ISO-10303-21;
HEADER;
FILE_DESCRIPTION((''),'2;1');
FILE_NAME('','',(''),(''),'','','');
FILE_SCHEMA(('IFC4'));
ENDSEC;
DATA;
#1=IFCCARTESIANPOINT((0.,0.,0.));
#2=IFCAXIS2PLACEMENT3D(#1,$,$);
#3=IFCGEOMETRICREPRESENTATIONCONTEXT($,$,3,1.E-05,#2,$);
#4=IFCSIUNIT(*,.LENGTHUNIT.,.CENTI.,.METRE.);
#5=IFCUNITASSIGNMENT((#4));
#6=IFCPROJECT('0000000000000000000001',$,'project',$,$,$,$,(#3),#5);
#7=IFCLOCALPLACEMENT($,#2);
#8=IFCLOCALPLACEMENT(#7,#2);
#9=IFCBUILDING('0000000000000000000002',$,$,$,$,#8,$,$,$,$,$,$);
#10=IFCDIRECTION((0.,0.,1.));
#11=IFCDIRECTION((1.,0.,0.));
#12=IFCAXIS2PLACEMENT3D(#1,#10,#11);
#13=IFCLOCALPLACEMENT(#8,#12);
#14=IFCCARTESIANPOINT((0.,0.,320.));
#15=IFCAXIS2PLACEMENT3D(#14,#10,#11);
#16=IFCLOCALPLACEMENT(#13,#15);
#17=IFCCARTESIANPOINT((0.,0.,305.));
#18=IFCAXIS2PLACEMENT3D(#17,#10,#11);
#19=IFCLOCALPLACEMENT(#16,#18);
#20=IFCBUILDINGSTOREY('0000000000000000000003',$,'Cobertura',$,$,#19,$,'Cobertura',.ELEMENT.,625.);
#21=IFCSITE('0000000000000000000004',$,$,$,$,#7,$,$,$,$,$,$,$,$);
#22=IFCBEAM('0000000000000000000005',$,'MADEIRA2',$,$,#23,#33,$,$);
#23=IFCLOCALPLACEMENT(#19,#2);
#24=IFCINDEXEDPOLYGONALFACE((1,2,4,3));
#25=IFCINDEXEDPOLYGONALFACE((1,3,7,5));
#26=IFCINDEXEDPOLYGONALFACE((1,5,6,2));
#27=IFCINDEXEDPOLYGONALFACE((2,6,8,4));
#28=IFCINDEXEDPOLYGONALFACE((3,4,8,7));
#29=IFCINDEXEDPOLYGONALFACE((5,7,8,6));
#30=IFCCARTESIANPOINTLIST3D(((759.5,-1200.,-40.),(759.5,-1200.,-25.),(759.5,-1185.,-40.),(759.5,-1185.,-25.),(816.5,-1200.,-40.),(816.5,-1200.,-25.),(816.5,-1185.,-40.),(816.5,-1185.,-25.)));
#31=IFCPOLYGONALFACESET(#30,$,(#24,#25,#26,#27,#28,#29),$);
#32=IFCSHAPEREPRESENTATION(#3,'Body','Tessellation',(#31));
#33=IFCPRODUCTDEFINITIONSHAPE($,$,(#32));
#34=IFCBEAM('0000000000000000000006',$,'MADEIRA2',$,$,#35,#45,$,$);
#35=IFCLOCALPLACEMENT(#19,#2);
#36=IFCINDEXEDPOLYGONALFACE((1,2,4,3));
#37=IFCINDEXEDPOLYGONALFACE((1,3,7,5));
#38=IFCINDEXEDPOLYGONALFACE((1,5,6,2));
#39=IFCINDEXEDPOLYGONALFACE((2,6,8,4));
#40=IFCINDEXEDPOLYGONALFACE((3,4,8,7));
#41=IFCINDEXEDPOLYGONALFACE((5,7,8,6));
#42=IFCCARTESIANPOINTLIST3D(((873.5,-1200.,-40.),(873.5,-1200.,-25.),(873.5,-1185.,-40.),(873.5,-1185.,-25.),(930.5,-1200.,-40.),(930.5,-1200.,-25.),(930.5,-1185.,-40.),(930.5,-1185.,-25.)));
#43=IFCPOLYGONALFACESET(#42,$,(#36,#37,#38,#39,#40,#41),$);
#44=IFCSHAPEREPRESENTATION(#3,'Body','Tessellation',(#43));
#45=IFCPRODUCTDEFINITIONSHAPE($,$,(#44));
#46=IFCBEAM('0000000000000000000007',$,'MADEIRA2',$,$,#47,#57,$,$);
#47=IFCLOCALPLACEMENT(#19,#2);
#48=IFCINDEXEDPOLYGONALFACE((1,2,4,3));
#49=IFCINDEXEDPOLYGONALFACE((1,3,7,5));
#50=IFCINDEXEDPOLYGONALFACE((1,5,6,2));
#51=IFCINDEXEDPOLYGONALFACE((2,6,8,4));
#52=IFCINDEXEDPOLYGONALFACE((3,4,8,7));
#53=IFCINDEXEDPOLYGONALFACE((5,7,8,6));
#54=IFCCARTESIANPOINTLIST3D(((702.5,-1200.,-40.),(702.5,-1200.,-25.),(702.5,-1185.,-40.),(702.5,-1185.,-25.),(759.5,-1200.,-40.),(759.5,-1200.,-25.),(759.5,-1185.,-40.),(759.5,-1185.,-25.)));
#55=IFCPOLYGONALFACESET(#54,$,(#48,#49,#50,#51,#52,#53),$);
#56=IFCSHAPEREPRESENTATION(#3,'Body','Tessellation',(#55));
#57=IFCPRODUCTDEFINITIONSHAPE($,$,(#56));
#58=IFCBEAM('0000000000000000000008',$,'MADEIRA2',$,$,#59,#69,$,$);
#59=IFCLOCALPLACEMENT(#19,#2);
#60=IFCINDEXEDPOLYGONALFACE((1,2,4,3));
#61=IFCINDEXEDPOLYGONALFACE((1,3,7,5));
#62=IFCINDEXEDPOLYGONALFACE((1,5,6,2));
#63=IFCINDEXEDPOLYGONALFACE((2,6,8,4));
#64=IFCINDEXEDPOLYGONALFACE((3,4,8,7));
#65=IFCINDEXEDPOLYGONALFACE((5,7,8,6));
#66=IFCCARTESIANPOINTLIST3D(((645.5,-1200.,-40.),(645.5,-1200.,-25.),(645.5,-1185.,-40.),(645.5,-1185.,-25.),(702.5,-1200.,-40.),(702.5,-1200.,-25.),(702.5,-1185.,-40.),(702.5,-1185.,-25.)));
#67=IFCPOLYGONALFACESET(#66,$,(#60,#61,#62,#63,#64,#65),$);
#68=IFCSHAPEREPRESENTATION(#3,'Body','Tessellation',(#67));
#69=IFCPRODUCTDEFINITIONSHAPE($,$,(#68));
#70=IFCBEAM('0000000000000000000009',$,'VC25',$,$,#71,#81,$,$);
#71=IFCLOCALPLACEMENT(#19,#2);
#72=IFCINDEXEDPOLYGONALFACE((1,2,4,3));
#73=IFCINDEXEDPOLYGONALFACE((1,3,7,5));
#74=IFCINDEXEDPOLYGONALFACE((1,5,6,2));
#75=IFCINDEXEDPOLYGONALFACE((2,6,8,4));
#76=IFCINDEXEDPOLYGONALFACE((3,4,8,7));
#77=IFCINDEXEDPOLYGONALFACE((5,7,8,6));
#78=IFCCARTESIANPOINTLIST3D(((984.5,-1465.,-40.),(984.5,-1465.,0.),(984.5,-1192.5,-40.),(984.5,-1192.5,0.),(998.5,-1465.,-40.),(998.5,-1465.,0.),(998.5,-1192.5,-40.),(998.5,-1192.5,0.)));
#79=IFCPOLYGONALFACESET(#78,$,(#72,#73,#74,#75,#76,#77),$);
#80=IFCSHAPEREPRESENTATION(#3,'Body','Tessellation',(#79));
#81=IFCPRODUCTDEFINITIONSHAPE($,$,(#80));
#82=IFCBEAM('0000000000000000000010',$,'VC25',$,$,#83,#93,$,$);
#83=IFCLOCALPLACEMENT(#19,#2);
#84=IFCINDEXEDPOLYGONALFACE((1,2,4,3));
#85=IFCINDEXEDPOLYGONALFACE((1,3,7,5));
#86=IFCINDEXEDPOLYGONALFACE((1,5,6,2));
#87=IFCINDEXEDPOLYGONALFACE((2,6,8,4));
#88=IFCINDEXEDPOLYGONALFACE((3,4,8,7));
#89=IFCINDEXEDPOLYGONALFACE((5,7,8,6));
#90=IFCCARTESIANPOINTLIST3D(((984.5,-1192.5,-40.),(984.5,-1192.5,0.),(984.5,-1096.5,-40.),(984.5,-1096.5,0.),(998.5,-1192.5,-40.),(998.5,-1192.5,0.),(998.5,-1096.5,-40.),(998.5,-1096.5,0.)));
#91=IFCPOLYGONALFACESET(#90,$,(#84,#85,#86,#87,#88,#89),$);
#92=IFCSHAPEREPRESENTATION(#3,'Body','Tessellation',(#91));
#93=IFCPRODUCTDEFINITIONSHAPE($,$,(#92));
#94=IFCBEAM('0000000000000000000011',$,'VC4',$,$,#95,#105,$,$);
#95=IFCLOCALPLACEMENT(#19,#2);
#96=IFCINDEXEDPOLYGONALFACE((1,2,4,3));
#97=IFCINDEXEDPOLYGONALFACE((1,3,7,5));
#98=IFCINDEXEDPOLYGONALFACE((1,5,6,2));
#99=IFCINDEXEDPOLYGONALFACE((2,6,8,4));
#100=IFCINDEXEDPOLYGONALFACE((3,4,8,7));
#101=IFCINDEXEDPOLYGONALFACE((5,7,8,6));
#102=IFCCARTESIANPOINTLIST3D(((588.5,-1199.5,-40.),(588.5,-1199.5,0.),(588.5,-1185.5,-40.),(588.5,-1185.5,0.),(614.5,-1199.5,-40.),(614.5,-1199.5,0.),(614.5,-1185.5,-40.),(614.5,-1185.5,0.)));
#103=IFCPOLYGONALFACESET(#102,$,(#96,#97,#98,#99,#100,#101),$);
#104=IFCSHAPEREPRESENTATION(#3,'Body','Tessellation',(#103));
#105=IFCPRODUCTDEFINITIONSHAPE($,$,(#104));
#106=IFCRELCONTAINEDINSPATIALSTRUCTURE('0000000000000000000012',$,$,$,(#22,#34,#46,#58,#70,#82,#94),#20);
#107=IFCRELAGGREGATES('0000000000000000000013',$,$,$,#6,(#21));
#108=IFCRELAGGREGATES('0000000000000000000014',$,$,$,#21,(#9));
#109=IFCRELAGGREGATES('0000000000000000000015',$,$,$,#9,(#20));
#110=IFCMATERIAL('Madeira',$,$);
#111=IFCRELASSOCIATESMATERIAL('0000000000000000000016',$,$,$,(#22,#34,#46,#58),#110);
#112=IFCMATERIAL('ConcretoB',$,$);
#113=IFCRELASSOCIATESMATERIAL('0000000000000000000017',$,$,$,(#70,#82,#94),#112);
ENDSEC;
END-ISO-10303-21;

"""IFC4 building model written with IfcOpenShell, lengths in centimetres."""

from ifc_helpers import new_model, si_unit, frame, origin, origin_with_axes, place, context, project, spatial, polyline, outline, extrude, material, element, save


model = new_model("IFC4")

# Units and contexts
context_of_model = context(None, 3, precision=1e-05, world=origin())
ifc_project = project(units=[si_unit("LENGTHUNIT", "METRE", prefix="CENTI")], contexts=[context_of_model])

# Site, building, storey
site_placement = place(None, origin())
site = spatial("IfcSite", under=ifc_project, at=site_placement)
building_placement = place(site_placement, origin())
building = spatial("IfcBuilding", under=site, at=building_placement)
placement_1 = place(building_placement, origin_with_axes())
placement_2 = place(placement_1, frame((0.0, 0.0, 320.0), z_axis=(0.0, 0.0, 1.0), x_axis=(1.0, 0.0, 0.0)))
storey_placement = place(placement_2, frame((0.0, 0.0, 305.0), z_axis=(0.0, 0.0, 1.0), x_axis=(1.0, 0.0, 0.0)))
storey = spatial("IfcBuildingStorey", under=building, at=storey_placement, Name="Cobertura", LongName="Cobertura", CompositionType="ELEMENT", Elevation=625.0)

# Shared definitions
ifc_material_1 = material(Name="ConcretoB")

# Beams
ifc_material_2 = material(Name="Madeira")
for number, where, z_axis, x_axis, name in (
    (1, (788.0, -1192.5, -25.0), (0.0, 0.0, 1.0), (1.0, 0.0, 0.0), "MADEIRA2"),
    (2, (902.0, -1192.5, -25.0), (0.0, 0.0, 1.0), (1.0, 0.0, 0.0), "MADEIRA2"),
    (3, (731.0, -1192.5, -25.0), (0.0, 0.0, 1.0), (1.0, 0.0, 0.0), "MADEIRA2"),
    (4, (674.0, -1192.5, -25.0), (0.0, 0.0, 1.0), (1.0, 0.0, 0.0), "MADEIRA2"),
):
    element("IfcBeam", number, at=place(storey_placement, frame(where, z_axis=z_axis, x_axis=x_axis)), inside=storey, material=ifc_material_2, Name=name, context=context_of_model, shape_type="SolidModel", body=[
        extrude(outline(polyline([(-7.5, -7.5), (-7.5, 7.5), (7.5, 7.5), (7.5, -7.5), (-7.5, -7.5)])), frame((-28.5, 0.0, -7.5), z_axis=(1.0, 0.0, 0.0), x_axis=(0.0, -1.0, 0.0)), (0.0, 0.0, 1.0), 57.0),
    ])
beam_1_placement = place(storey_placement, frame((991.5, -1328.75, 0.0), z_axis=(0.0, 0.0, 1.0), x_axis=(1.0, 0.0, 0.0)))
element("IfcBeam", 5, at=beam_1_placement, inside=storey, material=ifc_material_1, Name="VC25", context=context_of_model, shape_type="SolidModel", body=[
    extrude(outline(polyline([(-7.0, -20.0), (7.0, -20.0), (7.0, 20.0), (-7.0, 20.0), (-7.0, -20.0)])), frame((0.0, -136.25, -20.0), z_axis=(0.0, 1.0, 0.0), x_axis=(1.0, 0.0, 0.0)), (0.0, 0.0, 1.0), 272.5),
])
beam_2_placement = place(storey_placement, frame((991.5, -1144.5, 0.0), z_axis=(0.0, 0.0, 1.0), x_axis=(1.0, 0.0, 0.0)))
element("IfcBeam", 6, at=beam_2_placement, inside=storey, material=ifc_material_1, Name="VC25", context=context_of_model, shape_type="SolidModel", body=[
    extrude(outline(polyline([(-7.0, -20.0), (7.0, -20.0), (7.0, 20.0), (-7.0, 20.0), (-7.0, -20.0)])), frame((0.0, -48.0, -20.0), z_axis=(0.0, 1.0, 0.0), x_axis=(1.0, 0.0, 0.0)), (0.0, 0.0, 1.0), 96.0),
])
beam_3_placement = place(storey_placement, frame((601.5, -1192.5, 0.0), z_axis=(0.0, 0.0, 1.0), x_axis=(1.0, 0.0, 0.0)))
element("IfcBeam", 7, at=beam_3_placement, inside=storey, material=ifc_material_1, Name="VC4", context=context_of_model, shape_type="SolidModel", body=[
    extrude(outline(polyline([(-7.0, -20.0), (7.0, -20.0), (7.0, 20.0), (-7.0, 20.0), (-7.0, -20.0)])), frame((-13.0, 0.0, -20.0), z_axis=(1.0, 0.0, 0.0), x_axis=(0.0, -1.0, 0.0)), (0.0, 0.0, 1.0), 26.0),
])

save(model, "model.ifc")
